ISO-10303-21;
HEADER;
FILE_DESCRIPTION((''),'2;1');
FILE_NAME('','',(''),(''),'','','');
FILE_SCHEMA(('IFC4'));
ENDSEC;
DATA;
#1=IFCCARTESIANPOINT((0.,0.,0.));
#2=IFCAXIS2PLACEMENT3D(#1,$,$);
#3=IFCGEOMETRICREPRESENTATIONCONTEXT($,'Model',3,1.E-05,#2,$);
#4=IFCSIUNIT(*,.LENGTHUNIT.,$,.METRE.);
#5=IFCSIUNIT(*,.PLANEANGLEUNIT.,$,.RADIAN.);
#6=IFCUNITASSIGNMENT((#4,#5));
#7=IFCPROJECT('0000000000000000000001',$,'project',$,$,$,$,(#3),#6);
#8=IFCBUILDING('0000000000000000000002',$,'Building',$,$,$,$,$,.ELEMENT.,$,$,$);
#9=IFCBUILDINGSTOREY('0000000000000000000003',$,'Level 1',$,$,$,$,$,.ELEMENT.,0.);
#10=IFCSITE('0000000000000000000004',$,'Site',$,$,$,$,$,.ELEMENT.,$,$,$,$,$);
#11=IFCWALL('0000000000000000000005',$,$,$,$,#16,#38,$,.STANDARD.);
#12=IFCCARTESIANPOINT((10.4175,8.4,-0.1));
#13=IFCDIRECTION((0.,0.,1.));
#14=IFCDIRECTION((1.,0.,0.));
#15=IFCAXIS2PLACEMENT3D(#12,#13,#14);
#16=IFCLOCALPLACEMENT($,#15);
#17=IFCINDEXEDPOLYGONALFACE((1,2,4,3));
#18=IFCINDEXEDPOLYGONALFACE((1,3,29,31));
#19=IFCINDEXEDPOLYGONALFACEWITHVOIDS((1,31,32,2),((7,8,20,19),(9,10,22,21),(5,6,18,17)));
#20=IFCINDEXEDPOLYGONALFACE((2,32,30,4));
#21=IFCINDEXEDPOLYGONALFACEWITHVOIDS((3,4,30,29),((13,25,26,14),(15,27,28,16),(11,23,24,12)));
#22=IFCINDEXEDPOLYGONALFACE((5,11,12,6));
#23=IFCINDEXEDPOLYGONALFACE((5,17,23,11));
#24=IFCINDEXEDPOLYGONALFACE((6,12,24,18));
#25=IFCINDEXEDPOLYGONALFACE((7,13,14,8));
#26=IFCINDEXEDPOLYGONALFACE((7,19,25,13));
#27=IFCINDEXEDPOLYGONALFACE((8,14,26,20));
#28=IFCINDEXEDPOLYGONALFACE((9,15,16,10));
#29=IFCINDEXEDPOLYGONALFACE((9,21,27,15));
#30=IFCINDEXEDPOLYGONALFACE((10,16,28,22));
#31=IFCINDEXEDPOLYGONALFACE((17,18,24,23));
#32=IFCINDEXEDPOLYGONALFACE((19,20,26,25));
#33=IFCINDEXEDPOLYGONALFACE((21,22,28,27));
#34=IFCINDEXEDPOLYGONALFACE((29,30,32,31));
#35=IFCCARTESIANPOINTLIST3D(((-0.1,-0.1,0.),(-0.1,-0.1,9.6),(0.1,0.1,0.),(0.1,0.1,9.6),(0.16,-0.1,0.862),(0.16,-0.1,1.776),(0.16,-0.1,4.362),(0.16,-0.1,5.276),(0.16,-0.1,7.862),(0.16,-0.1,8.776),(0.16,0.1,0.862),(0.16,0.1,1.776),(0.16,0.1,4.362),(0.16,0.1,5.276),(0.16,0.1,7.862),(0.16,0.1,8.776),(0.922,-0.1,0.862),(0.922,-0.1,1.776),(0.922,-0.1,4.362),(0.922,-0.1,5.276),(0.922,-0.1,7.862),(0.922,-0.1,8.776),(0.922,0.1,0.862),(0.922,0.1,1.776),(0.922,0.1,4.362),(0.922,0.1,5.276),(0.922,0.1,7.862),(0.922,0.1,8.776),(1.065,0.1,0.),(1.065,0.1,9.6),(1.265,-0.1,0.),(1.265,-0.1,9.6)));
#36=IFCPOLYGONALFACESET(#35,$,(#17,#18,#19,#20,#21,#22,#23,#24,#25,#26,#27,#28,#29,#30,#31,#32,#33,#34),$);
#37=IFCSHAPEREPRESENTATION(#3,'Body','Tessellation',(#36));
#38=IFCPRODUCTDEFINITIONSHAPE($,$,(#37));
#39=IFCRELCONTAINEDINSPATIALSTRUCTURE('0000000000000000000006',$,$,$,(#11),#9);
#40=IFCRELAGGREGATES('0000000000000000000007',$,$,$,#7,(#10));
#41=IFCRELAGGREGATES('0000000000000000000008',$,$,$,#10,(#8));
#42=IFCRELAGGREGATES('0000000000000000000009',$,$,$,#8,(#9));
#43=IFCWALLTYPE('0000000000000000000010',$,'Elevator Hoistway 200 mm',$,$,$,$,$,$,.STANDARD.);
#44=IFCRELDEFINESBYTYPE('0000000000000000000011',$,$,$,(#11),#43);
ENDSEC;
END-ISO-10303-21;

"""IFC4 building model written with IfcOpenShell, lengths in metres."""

from ifc_helpers import new_model, si_unit, frame, origin, origin_2d, place, context, project, spatial, polyline, rectangle, outline, extrude, type_object, element, save


model = new_model("IFC4")

# Units and contexts
model_context = context("Model", 3, precision=1e-05, world=origin())
ifc_project = project(units=[si_unit("LENGTHUNIT", "METRE"), si_unit("PLANEANGLEUNIT", "RADIAN")], contexts=[model_context])

# Site, building, storey
site = spatial("IfcSite", under=ifc_project, Name="Site", CompositionType="ELEMENT")
building = spatial("IfcBuilding", under=site, Name="Building", CompositionType="ELEMENT")
storey = spatial("IfcBuildingStorey", under=building, Name="Level 1", CompositionType="ELEMENT", Elevation=0.0)

# Shared definitions
wall_type = type_object("IfcWallType", Name="Elevator Hoistway 200 mm", PredefinedType="STANDARD")

# Wall, openings
wall_1_placement = place(None, frame((10.4175, 8.4, -0.1), z_axis=(0.0, 0.0, 1.0), x_axis=(1.0, 0.0, 0.0)))
wall_1 = element("IfcWall", 1, at=wall_1_placement, inside=storey, type_object=wall_type, PredefinedType="STANDARD", context=model_context, shape_type="SweptSolid", body=[
    extrude(outline(polyline([(-0.1, -0.1), (1.265, -0.1), (1.065, 0.1), (0.1, 0.1), (-0.1, -0.1)])), origin(), (0.0, 0.0, 1.0), 9.6),
])
opening_1_placement = place(wall_1_placement, frame((0.541, 0.0, 0.862), z_axis=(0.0, 0.0, 1.0), x_axis=(1.0, 0.0, 0.0)))
element("IfcOpeningElement", 2, at=opening_1_placement, cuts=wall_1, PredefinedType="OPENING", context=model_context, shape_type="SweptSolid", body=[
    extrude(rectangle(XDim=0.762, YDim=0.202, at=origin_2d()), origin(), (0.0, 0.0, 1.0), 0.914),
])
opening_2_placement = place(wall_1_placement, frame((0.541, 0.0, 4.362), z_axis=(0.0, 0.0, 1.0), x_axis=(1.0, 0.0, 0.0)))
element("IfcOpeningElement", 3, at=opening_2_placement, cuts=wall_1, PredefinedType="OPENING", context=model_context, shape_type="SweptSolid", body=[
    extrude(rectangle(XDim=0.762, YDim=0.202, at=origin_2d()), origin(), (0.0, 0.0, 1.0), 0.914),
])
opening_3_placement = place(wall_1_placement, frame((0.541, 0.0, 7.862), z_axis=(0.0, 0.0, 1.0), x_axis=(1.0, 0.0, 0.0)))
element("IfcOpeningElement", 4, at=opening_3_placement, cuts=wall_1, PredefinedType="OPENING", context=model_context, shape_type="SweptSolid", body=[
    extrude(rectangle(XDim=0.762, YDim=0.202, at=origin_2d()), origin(), (0.0, 0.0, 1.0), 0.914),
])

save(model, "model.ifc")
